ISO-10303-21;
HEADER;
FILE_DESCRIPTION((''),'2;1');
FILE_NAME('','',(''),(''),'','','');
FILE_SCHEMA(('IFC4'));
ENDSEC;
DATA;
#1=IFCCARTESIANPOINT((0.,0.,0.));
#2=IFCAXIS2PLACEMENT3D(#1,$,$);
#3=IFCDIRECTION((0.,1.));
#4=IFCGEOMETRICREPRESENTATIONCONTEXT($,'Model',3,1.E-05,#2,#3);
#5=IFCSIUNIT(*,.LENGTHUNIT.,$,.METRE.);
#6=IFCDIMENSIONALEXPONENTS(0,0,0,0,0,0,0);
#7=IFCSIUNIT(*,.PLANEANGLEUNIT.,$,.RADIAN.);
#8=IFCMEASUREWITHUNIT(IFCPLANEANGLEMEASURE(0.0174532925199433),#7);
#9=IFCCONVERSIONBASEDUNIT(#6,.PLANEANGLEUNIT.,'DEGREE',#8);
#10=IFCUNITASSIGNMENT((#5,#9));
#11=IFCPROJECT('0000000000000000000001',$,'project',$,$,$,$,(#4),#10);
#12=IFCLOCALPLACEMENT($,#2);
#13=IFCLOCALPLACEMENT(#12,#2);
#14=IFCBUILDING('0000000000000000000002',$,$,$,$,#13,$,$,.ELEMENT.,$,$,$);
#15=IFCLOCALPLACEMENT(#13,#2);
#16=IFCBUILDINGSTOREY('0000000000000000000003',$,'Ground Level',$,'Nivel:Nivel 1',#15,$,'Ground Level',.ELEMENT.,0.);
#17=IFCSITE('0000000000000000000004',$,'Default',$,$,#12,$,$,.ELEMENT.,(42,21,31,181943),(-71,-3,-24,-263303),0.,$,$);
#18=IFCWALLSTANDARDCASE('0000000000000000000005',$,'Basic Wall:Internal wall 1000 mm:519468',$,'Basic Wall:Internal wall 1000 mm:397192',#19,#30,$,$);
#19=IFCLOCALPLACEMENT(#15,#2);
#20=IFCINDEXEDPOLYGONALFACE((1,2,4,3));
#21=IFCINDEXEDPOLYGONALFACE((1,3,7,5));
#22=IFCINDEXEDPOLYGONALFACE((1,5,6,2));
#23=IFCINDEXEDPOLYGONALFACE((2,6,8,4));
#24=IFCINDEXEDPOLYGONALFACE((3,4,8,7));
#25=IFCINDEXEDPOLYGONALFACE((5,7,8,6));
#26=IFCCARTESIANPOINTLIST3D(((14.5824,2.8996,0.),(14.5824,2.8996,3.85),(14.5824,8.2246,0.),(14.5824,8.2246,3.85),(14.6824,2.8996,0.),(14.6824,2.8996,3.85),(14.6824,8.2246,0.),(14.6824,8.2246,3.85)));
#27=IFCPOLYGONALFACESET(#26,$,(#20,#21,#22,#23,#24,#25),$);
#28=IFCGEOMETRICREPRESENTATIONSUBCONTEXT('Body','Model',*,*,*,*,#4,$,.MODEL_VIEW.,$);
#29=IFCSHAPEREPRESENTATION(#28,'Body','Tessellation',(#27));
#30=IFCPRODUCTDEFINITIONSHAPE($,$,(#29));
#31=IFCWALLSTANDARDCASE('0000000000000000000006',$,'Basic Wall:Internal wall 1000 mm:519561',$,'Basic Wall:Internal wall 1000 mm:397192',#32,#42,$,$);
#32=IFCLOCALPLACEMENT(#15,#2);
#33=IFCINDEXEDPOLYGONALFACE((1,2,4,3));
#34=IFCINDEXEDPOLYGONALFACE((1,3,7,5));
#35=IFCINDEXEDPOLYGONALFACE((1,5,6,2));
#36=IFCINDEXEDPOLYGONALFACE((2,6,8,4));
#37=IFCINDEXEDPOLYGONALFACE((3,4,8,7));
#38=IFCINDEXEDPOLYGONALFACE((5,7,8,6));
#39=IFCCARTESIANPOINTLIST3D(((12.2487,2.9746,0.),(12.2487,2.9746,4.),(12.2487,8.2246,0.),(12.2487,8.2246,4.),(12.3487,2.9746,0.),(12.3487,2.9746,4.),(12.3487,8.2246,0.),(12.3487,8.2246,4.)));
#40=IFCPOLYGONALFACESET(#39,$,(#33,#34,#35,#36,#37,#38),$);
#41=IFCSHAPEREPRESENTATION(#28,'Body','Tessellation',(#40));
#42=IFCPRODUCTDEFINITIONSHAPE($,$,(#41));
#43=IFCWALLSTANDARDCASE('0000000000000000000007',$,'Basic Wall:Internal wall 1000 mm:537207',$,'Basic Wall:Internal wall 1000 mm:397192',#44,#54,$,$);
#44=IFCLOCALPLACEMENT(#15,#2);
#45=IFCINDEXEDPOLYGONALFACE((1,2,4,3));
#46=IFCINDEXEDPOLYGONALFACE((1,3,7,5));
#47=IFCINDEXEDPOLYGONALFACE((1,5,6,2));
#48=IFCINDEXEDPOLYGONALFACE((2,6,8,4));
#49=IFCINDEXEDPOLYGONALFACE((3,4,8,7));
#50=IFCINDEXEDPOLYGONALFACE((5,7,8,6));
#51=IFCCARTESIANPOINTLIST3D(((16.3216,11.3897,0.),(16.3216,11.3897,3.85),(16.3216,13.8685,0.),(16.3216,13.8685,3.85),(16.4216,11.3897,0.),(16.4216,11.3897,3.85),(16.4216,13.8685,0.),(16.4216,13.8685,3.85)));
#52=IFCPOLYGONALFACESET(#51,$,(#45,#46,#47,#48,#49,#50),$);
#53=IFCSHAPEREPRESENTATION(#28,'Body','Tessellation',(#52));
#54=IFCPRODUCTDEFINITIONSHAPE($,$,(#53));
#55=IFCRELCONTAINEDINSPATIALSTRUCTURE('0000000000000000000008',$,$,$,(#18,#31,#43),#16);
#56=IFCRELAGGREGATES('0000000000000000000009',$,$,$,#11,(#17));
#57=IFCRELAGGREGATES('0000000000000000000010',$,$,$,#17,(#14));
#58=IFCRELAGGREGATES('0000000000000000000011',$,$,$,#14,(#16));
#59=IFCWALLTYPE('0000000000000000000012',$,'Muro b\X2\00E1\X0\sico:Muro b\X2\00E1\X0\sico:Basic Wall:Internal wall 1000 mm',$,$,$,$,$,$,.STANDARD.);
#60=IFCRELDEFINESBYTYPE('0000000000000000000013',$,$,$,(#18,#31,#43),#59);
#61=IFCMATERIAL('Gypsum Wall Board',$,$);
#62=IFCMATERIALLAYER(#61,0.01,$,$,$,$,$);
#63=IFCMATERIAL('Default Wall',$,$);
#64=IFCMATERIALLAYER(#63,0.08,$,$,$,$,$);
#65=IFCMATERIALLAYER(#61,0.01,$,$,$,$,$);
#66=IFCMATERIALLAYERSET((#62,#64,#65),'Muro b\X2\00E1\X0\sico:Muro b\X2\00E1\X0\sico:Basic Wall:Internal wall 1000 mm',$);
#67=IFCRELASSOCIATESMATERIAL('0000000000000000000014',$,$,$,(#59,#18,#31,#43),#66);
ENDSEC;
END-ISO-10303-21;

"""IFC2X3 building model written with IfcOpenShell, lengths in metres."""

from ifc_helpers import new_model, entity, si_unit, converted_unit, direction, frame, frame_2d, origin, place, context, subcontext, project, spatial, rectangle, extrude, material, layer, layer_set, layer_usage, type_object, element, save


model = new_model("IFC2X3")

# Units and contexts
model_context = context("Model", 3, precision=1e-05, world=origin(), true_north=direction((0.0, 1.0)))
body_context = subcontext(model_context, "Body", "Model", "MODEL_VIEW")
ifc_project = project(units=[si_unit("LENGTHUNIT", "METRE"), converted_unit("PLANEANGLEUNIT", "DEGREE", entity("IfcPlaneAngleMeasure", 0.0174532925199433), si_unit("PLANEANGLEUNIT", "RADIAN"), dimensions=[0, 0, 0, 0, 0, 0, 0])], contexts=[model_context])

# Site, building, storey
site_placement = place(None, origin())
site = spatial("IfcSite", under=ifc_project, at=site_placement, Name="Default", CompositionType="ELEMENT", RefLatitude=(42, 21, 31, 181943), RefLongitude=(-71, -3, -24, -263303), RefElevation=0.0)
building_placement = place(site_placement, origin())
building = spatial("IfcBuilding", under=site, at=building_placement, CompositionType="ELEMENT")
storey_placement = place(building_placement, origin())
storey = spatial("IfcBuildingStorey", under=building, at=storey_placement, Name="Ground Level", ObjectType="Nivel:Nivel 1", LongName="Ground Level", CompositionType="ELEMENT", Elevation=0.0)

# Shared definitions
ifc_material_1 = material(Name="Gypsum Wall Board")
ifc_layer_1 = layer(ifc_material_1, 0.01)
ifc_material_2 = material(Name="Default Wall")
ifc_layer_2 = layer(ifc_material_2, 0.08)
ifc_layer_3 = layer(ifc_material_1, 0.01)
ifc_layer_set = layer_set([ifc_layer_1, ifc_layer_2, ifc_layer_3], Name="Muro básico:Muro básico:Basic Wall:Internal wall 1000 mm")
wall_type = type_object("IfcWallType", Name="Muro básico:Muro básico:Basic Wall:Internal wall 1000 mm", PredefinedType="STANDARD", material=ifc_layer_set)

# Walls
ifc_layer_usage_1 = layer_usage(ifc_layer_set, "AXIS2", "NEGATIVE", 0.05)
wall_1_placement = place(storey_placement, frame((14.6324, 2.8996, 0.0), z_axis=(0.0, 0.0, 1.0), x_axis=(0.0, 1.0, 0.0)))
element("IfcWallStandardCase", 1, at=wall_1_placement, inside=storey, type_object=wall_type, material=ifc_layer_usage_1, Name="Basic Wall:Internal wall 1000 mm:519468", ObjectType="Basic Wall:Internal wall 1000 mm:397192", context=body_context, shape_type="SweptSolid", body=[
    extrude(rectangle(XDim=5.325, YDim=0.1, at=frame_2d((2.6625, 0.0), x_axis=(-1.0, 0.0))), origin(), (0.0, 0.0, 1.0), 3.85),
])
ifc_layer_usage_2 = layer_usage(ifc_layer_set, "AXIS2", "NEGATIVE", 0.05)
wall_2_placement = place(storey_placement, frame((12.2987, 2.9746, 0.0), z_axis=(0.0, 0.0, 1.0), x_axis=(0.0, 1.0, 0.0)))
element("IfcWallStandardCase", 2, at=wall_2_placement, inside=storey, type_object=wall_type, material=ifc_layer_usage_2, Name="Basic Wall:Internal wall 1000 mm:519561", ObjectType="Basic Wall:Internal wall 1000 mm:397192", context=body_context, shape_type="SweptSolid", body=[
    extrude(rectangle(XDim=5.25, YDim=0.1, at=frame_2d((2.625, 0.0), x_axis=(-1.0, 0.0))), origin(), (0.0, 0.0, 1.0), 4.0),
])
ifc_layer_usage_3 = layer_usage(ifc_layer_set, "AXIS2", "NEGATIVE", 0.05)
wall_3_placement = place(storey_placement, frame((16.3716, 11.3897, 0.0), z_axis=(0.0, 0.0, 1.0), x_axis=(0.0, 1.0, 0.0)))
element("IfcWallStandardCase", 3, at=wall_3_placement, inside=storey, type_object=wall_type, material=ifc_layer_usage_3, Name="Basic Wall:Internal wall 1000 mm:537207", ObjectType="Basic Wall:Internal wall 1000 mm:397192", context=body_context, shape_type="SweptSolid", body=[
    extrude(rectangle(XDim=2.4788, YDim=0.1, at=frame_2d((1.2394, 0.0), x_axis=(-1.0, 0.0))), origin(), (0.0, 0.0, 1.0), 3.85),
])

save(model, "model.ifc")
